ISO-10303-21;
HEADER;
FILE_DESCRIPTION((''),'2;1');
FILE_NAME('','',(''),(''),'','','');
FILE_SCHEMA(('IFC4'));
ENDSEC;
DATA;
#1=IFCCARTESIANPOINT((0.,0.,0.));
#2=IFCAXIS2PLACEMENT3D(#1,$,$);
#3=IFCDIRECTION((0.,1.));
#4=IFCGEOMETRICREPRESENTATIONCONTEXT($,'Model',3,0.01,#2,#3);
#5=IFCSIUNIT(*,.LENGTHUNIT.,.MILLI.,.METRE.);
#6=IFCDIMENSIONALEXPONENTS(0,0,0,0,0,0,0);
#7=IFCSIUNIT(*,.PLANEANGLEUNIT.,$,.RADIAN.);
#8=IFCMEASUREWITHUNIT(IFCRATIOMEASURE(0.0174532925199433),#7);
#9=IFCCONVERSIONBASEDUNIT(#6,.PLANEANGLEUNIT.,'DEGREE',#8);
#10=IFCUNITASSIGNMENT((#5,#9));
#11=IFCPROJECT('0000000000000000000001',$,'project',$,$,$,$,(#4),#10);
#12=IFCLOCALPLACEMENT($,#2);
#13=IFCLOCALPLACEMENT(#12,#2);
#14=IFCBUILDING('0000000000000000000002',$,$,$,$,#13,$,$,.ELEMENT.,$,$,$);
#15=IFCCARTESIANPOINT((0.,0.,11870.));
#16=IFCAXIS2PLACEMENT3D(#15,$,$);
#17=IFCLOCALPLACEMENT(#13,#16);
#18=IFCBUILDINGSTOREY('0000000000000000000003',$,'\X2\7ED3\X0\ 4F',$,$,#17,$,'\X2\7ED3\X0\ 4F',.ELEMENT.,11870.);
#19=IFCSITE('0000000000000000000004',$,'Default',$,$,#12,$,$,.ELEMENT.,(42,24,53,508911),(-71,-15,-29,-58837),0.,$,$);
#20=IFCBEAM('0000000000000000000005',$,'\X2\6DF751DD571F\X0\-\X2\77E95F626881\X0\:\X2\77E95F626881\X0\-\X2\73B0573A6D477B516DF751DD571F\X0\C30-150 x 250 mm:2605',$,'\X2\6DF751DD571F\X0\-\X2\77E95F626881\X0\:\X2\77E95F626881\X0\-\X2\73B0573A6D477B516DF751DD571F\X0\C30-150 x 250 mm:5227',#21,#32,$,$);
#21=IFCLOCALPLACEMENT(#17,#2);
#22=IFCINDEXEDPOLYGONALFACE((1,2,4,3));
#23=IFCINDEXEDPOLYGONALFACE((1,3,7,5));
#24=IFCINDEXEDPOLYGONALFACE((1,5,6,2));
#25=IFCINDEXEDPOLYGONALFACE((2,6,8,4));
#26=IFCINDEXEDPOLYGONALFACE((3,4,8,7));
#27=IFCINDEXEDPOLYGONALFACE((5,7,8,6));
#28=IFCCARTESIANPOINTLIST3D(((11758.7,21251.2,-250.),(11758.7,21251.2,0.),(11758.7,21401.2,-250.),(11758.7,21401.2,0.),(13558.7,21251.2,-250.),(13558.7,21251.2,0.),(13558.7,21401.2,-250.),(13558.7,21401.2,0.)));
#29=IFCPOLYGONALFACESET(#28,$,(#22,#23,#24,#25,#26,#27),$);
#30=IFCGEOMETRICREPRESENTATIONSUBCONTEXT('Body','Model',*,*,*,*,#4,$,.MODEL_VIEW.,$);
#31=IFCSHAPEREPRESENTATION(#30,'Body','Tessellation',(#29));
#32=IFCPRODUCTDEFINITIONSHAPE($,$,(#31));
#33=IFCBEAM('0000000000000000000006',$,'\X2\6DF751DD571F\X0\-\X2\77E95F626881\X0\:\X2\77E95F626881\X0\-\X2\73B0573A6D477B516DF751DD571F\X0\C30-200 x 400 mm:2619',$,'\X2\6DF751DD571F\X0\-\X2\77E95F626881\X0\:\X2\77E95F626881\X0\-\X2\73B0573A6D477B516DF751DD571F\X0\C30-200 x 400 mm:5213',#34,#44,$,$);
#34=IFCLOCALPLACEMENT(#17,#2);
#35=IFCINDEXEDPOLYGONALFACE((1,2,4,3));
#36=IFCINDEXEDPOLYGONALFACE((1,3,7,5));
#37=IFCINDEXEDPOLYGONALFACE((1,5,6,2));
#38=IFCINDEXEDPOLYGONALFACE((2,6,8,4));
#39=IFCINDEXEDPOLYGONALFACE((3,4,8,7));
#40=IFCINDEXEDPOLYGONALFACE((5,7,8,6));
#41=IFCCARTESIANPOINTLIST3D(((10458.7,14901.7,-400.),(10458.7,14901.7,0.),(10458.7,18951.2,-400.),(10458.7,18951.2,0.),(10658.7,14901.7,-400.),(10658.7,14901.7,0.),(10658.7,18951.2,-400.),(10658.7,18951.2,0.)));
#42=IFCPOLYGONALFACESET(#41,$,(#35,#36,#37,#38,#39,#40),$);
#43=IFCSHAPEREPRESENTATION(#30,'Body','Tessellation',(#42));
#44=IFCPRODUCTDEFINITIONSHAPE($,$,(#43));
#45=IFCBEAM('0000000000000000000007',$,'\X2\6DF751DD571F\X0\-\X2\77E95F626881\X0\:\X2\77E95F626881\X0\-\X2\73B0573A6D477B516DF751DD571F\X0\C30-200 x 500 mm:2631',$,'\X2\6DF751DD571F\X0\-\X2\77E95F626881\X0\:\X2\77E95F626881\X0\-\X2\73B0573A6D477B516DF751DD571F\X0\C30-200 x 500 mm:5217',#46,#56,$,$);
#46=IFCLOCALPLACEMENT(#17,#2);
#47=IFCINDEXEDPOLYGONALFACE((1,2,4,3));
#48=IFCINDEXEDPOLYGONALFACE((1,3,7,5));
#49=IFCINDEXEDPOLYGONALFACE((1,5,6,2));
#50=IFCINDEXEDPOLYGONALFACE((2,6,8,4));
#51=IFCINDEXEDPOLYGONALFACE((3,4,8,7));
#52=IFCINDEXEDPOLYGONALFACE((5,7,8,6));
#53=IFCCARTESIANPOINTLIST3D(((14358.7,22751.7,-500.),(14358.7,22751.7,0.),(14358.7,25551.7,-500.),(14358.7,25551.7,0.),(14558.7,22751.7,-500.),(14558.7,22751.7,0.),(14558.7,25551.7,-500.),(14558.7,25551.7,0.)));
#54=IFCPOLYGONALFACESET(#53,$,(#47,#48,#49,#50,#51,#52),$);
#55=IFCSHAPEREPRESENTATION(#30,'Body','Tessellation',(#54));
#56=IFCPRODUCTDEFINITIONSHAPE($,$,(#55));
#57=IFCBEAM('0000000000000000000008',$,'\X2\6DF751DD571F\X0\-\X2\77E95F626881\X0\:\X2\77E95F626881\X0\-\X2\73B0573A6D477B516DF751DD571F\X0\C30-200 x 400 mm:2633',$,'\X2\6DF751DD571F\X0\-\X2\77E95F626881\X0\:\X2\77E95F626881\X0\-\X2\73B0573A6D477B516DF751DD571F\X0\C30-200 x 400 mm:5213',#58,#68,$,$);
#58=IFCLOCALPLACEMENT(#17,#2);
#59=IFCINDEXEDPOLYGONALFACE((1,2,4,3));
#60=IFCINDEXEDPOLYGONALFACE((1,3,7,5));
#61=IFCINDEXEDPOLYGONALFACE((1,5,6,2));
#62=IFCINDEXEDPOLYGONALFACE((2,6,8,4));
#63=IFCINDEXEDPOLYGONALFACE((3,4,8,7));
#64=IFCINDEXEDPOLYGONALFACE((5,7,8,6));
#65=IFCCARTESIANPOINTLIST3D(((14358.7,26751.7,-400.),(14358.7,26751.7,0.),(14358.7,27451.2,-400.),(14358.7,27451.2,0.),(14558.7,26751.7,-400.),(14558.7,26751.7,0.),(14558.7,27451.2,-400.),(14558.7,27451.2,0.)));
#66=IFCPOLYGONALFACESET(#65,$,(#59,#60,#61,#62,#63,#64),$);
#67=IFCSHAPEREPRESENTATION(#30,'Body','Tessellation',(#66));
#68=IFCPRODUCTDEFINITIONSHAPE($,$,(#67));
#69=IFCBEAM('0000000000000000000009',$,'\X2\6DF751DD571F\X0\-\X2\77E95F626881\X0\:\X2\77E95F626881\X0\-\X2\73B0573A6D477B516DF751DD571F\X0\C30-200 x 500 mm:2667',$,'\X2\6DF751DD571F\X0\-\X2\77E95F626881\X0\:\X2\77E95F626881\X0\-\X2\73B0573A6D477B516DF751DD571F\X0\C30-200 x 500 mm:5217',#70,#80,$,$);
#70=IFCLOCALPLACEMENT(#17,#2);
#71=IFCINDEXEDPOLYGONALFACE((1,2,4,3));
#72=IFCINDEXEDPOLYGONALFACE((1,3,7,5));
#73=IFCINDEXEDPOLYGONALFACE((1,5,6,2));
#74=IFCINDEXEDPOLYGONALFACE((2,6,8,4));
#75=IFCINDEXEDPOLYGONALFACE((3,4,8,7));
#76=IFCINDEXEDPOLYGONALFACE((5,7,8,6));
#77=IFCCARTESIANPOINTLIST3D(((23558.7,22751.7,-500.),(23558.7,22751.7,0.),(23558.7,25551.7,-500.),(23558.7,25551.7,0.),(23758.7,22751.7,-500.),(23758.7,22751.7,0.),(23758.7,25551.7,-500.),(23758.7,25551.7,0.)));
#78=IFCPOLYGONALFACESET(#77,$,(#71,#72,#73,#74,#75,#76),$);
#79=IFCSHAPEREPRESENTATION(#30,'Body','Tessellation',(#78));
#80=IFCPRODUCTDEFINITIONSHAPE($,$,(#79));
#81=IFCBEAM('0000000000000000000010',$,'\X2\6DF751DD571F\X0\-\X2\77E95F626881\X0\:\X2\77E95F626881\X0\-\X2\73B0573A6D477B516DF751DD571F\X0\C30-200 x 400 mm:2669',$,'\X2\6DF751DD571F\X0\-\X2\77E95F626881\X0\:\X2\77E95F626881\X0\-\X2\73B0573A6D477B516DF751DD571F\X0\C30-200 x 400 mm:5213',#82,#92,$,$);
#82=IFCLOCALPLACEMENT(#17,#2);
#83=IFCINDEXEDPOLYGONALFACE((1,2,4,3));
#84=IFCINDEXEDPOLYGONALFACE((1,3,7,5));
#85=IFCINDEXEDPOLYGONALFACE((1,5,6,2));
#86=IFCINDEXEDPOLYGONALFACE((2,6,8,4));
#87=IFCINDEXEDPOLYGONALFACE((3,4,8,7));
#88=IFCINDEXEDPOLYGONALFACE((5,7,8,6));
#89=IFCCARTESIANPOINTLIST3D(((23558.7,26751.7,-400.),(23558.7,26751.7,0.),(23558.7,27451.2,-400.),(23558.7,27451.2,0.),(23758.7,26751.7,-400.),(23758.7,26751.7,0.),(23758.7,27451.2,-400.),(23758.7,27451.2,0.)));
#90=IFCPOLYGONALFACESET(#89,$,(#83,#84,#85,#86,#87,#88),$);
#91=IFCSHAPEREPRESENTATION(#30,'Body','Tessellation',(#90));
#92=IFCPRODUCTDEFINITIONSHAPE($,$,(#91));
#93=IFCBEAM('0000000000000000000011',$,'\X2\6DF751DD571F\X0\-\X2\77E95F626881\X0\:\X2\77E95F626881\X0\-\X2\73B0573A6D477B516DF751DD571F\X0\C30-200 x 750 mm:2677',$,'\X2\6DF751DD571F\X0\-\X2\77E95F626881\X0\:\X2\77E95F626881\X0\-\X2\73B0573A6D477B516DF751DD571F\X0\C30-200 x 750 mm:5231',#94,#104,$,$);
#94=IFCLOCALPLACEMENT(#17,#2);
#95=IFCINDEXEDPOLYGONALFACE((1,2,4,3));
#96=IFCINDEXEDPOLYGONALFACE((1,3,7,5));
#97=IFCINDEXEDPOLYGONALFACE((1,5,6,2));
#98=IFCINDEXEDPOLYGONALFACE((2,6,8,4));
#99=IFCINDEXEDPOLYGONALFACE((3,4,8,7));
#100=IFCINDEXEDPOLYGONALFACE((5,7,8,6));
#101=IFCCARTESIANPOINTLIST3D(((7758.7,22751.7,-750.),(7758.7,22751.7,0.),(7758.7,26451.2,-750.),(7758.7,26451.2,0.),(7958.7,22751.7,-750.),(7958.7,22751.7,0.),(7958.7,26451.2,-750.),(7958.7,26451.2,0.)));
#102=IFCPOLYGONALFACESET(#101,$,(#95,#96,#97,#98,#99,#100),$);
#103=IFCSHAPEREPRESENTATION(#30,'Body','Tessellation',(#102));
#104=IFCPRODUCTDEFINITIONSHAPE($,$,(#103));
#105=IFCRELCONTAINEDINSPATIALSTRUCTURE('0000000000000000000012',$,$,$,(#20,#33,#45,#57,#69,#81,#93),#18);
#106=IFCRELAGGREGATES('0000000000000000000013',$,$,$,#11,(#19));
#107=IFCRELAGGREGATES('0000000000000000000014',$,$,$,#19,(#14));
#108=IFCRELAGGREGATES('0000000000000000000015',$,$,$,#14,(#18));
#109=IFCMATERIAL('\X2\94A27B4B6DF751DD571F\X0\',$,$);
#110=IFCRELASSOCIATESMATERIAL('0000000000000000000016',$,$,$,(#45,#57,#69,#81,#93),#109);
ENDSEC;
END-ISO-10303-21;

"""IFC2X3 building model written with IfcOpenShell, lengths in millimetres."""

from ifc_helpers import new_model, entity, si_unit, converted_unit, direction, frame, frame_2d, origin, place, context, subcontext, project, spatial, rectangle, extrude, material, element, save


model = new_model("IFC2X3")

# Units and contexts
model_context = context("Model", 3, precision=0.01, world=origin(), true_north=direction((0.0, 1.0)))
body_context = subcontext(model_context, "Body", "Model", "MODEL_VIEW")
ifc_project = project(units=[si_unit("LENGTHUNIT", "METRE", prefix="MILLI"), converted_unit("PLANEANGLEUNIT", "DEGREE", entity("IfcRatioMeasure", 0.0174532925199433), si_unit("PLANEANGLEUNIT", "RADIAN"), dimensions=[0, 0, 0, 0, 0, 0, 0])], contexts=[model_context])

# Site, building, storey
site_placement = place(None, origin())
site = spatial("IfcSite", under=ifc_project, at=site_placement, Name="Default", CompositionType="ELEMENT", RefLatitude=(42, 24, 53, 508911), RefLongitude=(-71, -15, -29, -58837), RefElevation=0.0)
building_placement = place(site_placement, origin())
building = spatial("IfcBuilding", under=site, at=building_placement, CompositionType="ELEMENT")
storey_placement = place(building_placement, frame((0.0, 0.0, 11870.0)))
storey = spatial("IfcBuildingStorey", under=building, at=storey_placement, Name="结 4F", LongName="结 4F", CompositionType="ELEMENT", Elevation=11870.0)

# Beams
ifc_material = material(Name="钢筋混凝土")
beam_1_placement = place(storey_placement, frame((11683.7, 21326.2, 0.0)))
element("IfcBeam", 1, at=beam_1_placement, inside=storey, Name="混凝土-矩形梁:矩形梁-现场浇筑混凝土C30-150 x 250 mm:2605", ObjectType="混凝土-矩形梁:矩形梁-现场浇筑混凝土C30-150 x 250 mm:5227", context=body_context, shape_type="SweptSolid", body=[
    extrude(rectangle(XDim=250.0, YDim=150.0, at=frame_2d((0.0, 0.0), x_axis=(1.0, 0.0))), frame((75.0, 0.0, -125.0), z_axis=(1.0, 0.0, 0.0), x_axis=(0.0, 0.0, -1.0)), (0.0, 0.0, 1.0), 1800.0),
])
beam_2_placement = place(storey_placement, frame((10558.7, 14801.7, 0.0), z_axis=(0.0, 0.0, 1.0), x_axis=(0.0, 1.0, 0.0)))
element("IfcBeam", 2, at=beam_2_placement, inside=storey, Name="混凝土-矩形梁:矩形梁-现场浇筑混凝土C30-200 x 400 mm:2619", ObjectType="混凝土-矩形梁:矩形梁-现场浇筑混凝土C30-200 x 400 mm:5213", context=body_context, shape_type="SweptSolid", body=[
    extrude(rectangle(XDim=400.0, YDim=200.0, at=frame_2d((0.0, 0.0), x_axis=(1.0, 0.0))), frame((100.0, 0.0, -200.0), z_axis=(1.0, 0.0, 0.0), x_axis=(0.0, 0.0, -1.0)), (0.0, 0.0, 1.0), 4049.5),
])
beam_3_placement = place(storey_placement, frame((14458.7, 22651.7, 0.0), z_axis=(0.0, 0.0, 1.0), x_axis=(0.0, 1.0, 0.0)))
element("IfcBeam", 3, at=beam_3_placement, inside=storey, material=ifc_material, Name="混凝土-矩形梁:矩形梁-现场浇筑混凝土C30-200 x 500 mm:2631", ObjectType="混凝土-矩形梁:矩形梁-现场浇筑混凝土C30-200 x 500 mm:5217", context=body_context, shape_type="SweptSolid", body=[
    extrude(rectangle(XDim=500.0, YDim=200.0, at=frame_2d((0.0, 0.0), x_axis=(1.0, 0.0))), frame((100.0, 0.0, -250.0), z_axis=(1.0, 0.0, 0.0), x_axis=(0.0, 0.0, -1.0)), (0.0, 0.0, 1.0), 2800.0),
])
beam_4_placement = place(storey_placement, frame((14458.7, 26651.7, 0.0), z_axis=(0.0, 0.0, 1.0), x_axis=(0.0, 1.0, 0.0)))
element("IfcBeam", 4, at=beam_4_placement, inside=storey, material=ifc_material, Name="混凝土-矩形梁:矩形梁-现场浇筑混凝土C30-200 x 400 mm:2633", ObjectType="混凝土-矩形梁:矩形梁-现场浇筑混凝土C30-200 x 400 mm:5213", context=body_context, shape_type="SweptSolid", body=[
    extrude(rectangle(XDim=400.0, YDim=200.0, at=frame_2d((0.0, 0.0), x_axis=(1.0, 0.0))), frame((100.0, 0.0, -200.0), z_axis=(1.0, 0.0, 0.0), x_axis=(0.0, 0.0, -1.0)), (0.0, 0.0, 1.0), 699.5),
])
beam_5_placement = place(storey_placement, frame((23658.7, 22651.7, 0.0), z_axis=(0.0, 0.0, 1.0), x_axis=(0.0, 1.0, 0.0)))
element("IfcBeam", 5, at=beam_5_placement, inside=storey, material=ifc_material, Name="混凝土-矩形梁:矩形梁-现场浇筑混凝土C30-200 x 500 mm:2667", ObjectType="混凝土-矩形梁:矩形梁-现场浇筑混凝土C30-200 x 500 mm:5217", context=body_context, shape_type="SweptSolid", body=[
    extrude(rectangle(XDim=500.0, YDim=200.0, at=frame_2d((0.0, 0.0), x_axis=(1.0, 0.0))), frame((100.0, 0.0, -250.0), z_axis=(1.0, 0.0, 0.0), x_axis=(0.0, 0.0, -1.0)), (0.0, 0.0, 1.0), 2800.0),
])
beam_6_placement = place(storey_placement, frame((23658.7, 26651.7, 0.0), z_axis=(0.0, 0.0, 1.0), x_axis=(0.0, 1.0, 0.0)))
element("IfcBeam", 6, at=beam_6_placement, inside=storey, material=ifc_material, Name="混凝土-矩形梁:矩形梁-现场浇筑混凝土C30-200 x 400 mm:2669", ObjectType="混凝土-矩形梁:矩形梁-现场浇筑混凝土C30-200 x 400 mm:5213", context=body_context, shape_type="SweptSolid", body=[
    extrude(rectangle(XDim=400.0, YDim=200.0, at=frame_2d((0.0, 0.0), x_axis=(1.0, 0.0))), frame((100.0, 0.0, -200.0), z_axis=(1.0, 0.0, 0.0), x_axis=(0.0, 0.0, -1.0)), (0.0, 0.0, 1.0), 699.5),
])
beam_7_placement = place(storey_placement, frame((7858.7, 22651.7, 0.0), z_axis=(0.0, 0.0, 1.0), x_axis=(0.0, 1.0, 0.0)))
element("IfcBeam", 7, at=beam_7_placement, inside=storey, material=ifc_material, Name="混凝土-矩形梁:矩形梁-现场浇筑混凝土C30-200 x 750 mm:2677", ObjectType="混凝土-矩形梁:矩形梁-现场浇筑混凝土C30-200 x 750 mm:5231", context=body_context, shape_type="SweptSolid", body=[
    extrude(rectangle(XDim=750.0, YDim=200.0, at=frame_2d((0.0, 0.0), x_axis=(1.0, 0.0))), frame((100.0, 0.0, -375.0), z_axis=(1.0, 0.0, 0.0), x_axis=(0.0, 0.0, -1.0)), (0.0, 0.0, 1.0), 3699.5),
])

save(model, "model.ifc")
